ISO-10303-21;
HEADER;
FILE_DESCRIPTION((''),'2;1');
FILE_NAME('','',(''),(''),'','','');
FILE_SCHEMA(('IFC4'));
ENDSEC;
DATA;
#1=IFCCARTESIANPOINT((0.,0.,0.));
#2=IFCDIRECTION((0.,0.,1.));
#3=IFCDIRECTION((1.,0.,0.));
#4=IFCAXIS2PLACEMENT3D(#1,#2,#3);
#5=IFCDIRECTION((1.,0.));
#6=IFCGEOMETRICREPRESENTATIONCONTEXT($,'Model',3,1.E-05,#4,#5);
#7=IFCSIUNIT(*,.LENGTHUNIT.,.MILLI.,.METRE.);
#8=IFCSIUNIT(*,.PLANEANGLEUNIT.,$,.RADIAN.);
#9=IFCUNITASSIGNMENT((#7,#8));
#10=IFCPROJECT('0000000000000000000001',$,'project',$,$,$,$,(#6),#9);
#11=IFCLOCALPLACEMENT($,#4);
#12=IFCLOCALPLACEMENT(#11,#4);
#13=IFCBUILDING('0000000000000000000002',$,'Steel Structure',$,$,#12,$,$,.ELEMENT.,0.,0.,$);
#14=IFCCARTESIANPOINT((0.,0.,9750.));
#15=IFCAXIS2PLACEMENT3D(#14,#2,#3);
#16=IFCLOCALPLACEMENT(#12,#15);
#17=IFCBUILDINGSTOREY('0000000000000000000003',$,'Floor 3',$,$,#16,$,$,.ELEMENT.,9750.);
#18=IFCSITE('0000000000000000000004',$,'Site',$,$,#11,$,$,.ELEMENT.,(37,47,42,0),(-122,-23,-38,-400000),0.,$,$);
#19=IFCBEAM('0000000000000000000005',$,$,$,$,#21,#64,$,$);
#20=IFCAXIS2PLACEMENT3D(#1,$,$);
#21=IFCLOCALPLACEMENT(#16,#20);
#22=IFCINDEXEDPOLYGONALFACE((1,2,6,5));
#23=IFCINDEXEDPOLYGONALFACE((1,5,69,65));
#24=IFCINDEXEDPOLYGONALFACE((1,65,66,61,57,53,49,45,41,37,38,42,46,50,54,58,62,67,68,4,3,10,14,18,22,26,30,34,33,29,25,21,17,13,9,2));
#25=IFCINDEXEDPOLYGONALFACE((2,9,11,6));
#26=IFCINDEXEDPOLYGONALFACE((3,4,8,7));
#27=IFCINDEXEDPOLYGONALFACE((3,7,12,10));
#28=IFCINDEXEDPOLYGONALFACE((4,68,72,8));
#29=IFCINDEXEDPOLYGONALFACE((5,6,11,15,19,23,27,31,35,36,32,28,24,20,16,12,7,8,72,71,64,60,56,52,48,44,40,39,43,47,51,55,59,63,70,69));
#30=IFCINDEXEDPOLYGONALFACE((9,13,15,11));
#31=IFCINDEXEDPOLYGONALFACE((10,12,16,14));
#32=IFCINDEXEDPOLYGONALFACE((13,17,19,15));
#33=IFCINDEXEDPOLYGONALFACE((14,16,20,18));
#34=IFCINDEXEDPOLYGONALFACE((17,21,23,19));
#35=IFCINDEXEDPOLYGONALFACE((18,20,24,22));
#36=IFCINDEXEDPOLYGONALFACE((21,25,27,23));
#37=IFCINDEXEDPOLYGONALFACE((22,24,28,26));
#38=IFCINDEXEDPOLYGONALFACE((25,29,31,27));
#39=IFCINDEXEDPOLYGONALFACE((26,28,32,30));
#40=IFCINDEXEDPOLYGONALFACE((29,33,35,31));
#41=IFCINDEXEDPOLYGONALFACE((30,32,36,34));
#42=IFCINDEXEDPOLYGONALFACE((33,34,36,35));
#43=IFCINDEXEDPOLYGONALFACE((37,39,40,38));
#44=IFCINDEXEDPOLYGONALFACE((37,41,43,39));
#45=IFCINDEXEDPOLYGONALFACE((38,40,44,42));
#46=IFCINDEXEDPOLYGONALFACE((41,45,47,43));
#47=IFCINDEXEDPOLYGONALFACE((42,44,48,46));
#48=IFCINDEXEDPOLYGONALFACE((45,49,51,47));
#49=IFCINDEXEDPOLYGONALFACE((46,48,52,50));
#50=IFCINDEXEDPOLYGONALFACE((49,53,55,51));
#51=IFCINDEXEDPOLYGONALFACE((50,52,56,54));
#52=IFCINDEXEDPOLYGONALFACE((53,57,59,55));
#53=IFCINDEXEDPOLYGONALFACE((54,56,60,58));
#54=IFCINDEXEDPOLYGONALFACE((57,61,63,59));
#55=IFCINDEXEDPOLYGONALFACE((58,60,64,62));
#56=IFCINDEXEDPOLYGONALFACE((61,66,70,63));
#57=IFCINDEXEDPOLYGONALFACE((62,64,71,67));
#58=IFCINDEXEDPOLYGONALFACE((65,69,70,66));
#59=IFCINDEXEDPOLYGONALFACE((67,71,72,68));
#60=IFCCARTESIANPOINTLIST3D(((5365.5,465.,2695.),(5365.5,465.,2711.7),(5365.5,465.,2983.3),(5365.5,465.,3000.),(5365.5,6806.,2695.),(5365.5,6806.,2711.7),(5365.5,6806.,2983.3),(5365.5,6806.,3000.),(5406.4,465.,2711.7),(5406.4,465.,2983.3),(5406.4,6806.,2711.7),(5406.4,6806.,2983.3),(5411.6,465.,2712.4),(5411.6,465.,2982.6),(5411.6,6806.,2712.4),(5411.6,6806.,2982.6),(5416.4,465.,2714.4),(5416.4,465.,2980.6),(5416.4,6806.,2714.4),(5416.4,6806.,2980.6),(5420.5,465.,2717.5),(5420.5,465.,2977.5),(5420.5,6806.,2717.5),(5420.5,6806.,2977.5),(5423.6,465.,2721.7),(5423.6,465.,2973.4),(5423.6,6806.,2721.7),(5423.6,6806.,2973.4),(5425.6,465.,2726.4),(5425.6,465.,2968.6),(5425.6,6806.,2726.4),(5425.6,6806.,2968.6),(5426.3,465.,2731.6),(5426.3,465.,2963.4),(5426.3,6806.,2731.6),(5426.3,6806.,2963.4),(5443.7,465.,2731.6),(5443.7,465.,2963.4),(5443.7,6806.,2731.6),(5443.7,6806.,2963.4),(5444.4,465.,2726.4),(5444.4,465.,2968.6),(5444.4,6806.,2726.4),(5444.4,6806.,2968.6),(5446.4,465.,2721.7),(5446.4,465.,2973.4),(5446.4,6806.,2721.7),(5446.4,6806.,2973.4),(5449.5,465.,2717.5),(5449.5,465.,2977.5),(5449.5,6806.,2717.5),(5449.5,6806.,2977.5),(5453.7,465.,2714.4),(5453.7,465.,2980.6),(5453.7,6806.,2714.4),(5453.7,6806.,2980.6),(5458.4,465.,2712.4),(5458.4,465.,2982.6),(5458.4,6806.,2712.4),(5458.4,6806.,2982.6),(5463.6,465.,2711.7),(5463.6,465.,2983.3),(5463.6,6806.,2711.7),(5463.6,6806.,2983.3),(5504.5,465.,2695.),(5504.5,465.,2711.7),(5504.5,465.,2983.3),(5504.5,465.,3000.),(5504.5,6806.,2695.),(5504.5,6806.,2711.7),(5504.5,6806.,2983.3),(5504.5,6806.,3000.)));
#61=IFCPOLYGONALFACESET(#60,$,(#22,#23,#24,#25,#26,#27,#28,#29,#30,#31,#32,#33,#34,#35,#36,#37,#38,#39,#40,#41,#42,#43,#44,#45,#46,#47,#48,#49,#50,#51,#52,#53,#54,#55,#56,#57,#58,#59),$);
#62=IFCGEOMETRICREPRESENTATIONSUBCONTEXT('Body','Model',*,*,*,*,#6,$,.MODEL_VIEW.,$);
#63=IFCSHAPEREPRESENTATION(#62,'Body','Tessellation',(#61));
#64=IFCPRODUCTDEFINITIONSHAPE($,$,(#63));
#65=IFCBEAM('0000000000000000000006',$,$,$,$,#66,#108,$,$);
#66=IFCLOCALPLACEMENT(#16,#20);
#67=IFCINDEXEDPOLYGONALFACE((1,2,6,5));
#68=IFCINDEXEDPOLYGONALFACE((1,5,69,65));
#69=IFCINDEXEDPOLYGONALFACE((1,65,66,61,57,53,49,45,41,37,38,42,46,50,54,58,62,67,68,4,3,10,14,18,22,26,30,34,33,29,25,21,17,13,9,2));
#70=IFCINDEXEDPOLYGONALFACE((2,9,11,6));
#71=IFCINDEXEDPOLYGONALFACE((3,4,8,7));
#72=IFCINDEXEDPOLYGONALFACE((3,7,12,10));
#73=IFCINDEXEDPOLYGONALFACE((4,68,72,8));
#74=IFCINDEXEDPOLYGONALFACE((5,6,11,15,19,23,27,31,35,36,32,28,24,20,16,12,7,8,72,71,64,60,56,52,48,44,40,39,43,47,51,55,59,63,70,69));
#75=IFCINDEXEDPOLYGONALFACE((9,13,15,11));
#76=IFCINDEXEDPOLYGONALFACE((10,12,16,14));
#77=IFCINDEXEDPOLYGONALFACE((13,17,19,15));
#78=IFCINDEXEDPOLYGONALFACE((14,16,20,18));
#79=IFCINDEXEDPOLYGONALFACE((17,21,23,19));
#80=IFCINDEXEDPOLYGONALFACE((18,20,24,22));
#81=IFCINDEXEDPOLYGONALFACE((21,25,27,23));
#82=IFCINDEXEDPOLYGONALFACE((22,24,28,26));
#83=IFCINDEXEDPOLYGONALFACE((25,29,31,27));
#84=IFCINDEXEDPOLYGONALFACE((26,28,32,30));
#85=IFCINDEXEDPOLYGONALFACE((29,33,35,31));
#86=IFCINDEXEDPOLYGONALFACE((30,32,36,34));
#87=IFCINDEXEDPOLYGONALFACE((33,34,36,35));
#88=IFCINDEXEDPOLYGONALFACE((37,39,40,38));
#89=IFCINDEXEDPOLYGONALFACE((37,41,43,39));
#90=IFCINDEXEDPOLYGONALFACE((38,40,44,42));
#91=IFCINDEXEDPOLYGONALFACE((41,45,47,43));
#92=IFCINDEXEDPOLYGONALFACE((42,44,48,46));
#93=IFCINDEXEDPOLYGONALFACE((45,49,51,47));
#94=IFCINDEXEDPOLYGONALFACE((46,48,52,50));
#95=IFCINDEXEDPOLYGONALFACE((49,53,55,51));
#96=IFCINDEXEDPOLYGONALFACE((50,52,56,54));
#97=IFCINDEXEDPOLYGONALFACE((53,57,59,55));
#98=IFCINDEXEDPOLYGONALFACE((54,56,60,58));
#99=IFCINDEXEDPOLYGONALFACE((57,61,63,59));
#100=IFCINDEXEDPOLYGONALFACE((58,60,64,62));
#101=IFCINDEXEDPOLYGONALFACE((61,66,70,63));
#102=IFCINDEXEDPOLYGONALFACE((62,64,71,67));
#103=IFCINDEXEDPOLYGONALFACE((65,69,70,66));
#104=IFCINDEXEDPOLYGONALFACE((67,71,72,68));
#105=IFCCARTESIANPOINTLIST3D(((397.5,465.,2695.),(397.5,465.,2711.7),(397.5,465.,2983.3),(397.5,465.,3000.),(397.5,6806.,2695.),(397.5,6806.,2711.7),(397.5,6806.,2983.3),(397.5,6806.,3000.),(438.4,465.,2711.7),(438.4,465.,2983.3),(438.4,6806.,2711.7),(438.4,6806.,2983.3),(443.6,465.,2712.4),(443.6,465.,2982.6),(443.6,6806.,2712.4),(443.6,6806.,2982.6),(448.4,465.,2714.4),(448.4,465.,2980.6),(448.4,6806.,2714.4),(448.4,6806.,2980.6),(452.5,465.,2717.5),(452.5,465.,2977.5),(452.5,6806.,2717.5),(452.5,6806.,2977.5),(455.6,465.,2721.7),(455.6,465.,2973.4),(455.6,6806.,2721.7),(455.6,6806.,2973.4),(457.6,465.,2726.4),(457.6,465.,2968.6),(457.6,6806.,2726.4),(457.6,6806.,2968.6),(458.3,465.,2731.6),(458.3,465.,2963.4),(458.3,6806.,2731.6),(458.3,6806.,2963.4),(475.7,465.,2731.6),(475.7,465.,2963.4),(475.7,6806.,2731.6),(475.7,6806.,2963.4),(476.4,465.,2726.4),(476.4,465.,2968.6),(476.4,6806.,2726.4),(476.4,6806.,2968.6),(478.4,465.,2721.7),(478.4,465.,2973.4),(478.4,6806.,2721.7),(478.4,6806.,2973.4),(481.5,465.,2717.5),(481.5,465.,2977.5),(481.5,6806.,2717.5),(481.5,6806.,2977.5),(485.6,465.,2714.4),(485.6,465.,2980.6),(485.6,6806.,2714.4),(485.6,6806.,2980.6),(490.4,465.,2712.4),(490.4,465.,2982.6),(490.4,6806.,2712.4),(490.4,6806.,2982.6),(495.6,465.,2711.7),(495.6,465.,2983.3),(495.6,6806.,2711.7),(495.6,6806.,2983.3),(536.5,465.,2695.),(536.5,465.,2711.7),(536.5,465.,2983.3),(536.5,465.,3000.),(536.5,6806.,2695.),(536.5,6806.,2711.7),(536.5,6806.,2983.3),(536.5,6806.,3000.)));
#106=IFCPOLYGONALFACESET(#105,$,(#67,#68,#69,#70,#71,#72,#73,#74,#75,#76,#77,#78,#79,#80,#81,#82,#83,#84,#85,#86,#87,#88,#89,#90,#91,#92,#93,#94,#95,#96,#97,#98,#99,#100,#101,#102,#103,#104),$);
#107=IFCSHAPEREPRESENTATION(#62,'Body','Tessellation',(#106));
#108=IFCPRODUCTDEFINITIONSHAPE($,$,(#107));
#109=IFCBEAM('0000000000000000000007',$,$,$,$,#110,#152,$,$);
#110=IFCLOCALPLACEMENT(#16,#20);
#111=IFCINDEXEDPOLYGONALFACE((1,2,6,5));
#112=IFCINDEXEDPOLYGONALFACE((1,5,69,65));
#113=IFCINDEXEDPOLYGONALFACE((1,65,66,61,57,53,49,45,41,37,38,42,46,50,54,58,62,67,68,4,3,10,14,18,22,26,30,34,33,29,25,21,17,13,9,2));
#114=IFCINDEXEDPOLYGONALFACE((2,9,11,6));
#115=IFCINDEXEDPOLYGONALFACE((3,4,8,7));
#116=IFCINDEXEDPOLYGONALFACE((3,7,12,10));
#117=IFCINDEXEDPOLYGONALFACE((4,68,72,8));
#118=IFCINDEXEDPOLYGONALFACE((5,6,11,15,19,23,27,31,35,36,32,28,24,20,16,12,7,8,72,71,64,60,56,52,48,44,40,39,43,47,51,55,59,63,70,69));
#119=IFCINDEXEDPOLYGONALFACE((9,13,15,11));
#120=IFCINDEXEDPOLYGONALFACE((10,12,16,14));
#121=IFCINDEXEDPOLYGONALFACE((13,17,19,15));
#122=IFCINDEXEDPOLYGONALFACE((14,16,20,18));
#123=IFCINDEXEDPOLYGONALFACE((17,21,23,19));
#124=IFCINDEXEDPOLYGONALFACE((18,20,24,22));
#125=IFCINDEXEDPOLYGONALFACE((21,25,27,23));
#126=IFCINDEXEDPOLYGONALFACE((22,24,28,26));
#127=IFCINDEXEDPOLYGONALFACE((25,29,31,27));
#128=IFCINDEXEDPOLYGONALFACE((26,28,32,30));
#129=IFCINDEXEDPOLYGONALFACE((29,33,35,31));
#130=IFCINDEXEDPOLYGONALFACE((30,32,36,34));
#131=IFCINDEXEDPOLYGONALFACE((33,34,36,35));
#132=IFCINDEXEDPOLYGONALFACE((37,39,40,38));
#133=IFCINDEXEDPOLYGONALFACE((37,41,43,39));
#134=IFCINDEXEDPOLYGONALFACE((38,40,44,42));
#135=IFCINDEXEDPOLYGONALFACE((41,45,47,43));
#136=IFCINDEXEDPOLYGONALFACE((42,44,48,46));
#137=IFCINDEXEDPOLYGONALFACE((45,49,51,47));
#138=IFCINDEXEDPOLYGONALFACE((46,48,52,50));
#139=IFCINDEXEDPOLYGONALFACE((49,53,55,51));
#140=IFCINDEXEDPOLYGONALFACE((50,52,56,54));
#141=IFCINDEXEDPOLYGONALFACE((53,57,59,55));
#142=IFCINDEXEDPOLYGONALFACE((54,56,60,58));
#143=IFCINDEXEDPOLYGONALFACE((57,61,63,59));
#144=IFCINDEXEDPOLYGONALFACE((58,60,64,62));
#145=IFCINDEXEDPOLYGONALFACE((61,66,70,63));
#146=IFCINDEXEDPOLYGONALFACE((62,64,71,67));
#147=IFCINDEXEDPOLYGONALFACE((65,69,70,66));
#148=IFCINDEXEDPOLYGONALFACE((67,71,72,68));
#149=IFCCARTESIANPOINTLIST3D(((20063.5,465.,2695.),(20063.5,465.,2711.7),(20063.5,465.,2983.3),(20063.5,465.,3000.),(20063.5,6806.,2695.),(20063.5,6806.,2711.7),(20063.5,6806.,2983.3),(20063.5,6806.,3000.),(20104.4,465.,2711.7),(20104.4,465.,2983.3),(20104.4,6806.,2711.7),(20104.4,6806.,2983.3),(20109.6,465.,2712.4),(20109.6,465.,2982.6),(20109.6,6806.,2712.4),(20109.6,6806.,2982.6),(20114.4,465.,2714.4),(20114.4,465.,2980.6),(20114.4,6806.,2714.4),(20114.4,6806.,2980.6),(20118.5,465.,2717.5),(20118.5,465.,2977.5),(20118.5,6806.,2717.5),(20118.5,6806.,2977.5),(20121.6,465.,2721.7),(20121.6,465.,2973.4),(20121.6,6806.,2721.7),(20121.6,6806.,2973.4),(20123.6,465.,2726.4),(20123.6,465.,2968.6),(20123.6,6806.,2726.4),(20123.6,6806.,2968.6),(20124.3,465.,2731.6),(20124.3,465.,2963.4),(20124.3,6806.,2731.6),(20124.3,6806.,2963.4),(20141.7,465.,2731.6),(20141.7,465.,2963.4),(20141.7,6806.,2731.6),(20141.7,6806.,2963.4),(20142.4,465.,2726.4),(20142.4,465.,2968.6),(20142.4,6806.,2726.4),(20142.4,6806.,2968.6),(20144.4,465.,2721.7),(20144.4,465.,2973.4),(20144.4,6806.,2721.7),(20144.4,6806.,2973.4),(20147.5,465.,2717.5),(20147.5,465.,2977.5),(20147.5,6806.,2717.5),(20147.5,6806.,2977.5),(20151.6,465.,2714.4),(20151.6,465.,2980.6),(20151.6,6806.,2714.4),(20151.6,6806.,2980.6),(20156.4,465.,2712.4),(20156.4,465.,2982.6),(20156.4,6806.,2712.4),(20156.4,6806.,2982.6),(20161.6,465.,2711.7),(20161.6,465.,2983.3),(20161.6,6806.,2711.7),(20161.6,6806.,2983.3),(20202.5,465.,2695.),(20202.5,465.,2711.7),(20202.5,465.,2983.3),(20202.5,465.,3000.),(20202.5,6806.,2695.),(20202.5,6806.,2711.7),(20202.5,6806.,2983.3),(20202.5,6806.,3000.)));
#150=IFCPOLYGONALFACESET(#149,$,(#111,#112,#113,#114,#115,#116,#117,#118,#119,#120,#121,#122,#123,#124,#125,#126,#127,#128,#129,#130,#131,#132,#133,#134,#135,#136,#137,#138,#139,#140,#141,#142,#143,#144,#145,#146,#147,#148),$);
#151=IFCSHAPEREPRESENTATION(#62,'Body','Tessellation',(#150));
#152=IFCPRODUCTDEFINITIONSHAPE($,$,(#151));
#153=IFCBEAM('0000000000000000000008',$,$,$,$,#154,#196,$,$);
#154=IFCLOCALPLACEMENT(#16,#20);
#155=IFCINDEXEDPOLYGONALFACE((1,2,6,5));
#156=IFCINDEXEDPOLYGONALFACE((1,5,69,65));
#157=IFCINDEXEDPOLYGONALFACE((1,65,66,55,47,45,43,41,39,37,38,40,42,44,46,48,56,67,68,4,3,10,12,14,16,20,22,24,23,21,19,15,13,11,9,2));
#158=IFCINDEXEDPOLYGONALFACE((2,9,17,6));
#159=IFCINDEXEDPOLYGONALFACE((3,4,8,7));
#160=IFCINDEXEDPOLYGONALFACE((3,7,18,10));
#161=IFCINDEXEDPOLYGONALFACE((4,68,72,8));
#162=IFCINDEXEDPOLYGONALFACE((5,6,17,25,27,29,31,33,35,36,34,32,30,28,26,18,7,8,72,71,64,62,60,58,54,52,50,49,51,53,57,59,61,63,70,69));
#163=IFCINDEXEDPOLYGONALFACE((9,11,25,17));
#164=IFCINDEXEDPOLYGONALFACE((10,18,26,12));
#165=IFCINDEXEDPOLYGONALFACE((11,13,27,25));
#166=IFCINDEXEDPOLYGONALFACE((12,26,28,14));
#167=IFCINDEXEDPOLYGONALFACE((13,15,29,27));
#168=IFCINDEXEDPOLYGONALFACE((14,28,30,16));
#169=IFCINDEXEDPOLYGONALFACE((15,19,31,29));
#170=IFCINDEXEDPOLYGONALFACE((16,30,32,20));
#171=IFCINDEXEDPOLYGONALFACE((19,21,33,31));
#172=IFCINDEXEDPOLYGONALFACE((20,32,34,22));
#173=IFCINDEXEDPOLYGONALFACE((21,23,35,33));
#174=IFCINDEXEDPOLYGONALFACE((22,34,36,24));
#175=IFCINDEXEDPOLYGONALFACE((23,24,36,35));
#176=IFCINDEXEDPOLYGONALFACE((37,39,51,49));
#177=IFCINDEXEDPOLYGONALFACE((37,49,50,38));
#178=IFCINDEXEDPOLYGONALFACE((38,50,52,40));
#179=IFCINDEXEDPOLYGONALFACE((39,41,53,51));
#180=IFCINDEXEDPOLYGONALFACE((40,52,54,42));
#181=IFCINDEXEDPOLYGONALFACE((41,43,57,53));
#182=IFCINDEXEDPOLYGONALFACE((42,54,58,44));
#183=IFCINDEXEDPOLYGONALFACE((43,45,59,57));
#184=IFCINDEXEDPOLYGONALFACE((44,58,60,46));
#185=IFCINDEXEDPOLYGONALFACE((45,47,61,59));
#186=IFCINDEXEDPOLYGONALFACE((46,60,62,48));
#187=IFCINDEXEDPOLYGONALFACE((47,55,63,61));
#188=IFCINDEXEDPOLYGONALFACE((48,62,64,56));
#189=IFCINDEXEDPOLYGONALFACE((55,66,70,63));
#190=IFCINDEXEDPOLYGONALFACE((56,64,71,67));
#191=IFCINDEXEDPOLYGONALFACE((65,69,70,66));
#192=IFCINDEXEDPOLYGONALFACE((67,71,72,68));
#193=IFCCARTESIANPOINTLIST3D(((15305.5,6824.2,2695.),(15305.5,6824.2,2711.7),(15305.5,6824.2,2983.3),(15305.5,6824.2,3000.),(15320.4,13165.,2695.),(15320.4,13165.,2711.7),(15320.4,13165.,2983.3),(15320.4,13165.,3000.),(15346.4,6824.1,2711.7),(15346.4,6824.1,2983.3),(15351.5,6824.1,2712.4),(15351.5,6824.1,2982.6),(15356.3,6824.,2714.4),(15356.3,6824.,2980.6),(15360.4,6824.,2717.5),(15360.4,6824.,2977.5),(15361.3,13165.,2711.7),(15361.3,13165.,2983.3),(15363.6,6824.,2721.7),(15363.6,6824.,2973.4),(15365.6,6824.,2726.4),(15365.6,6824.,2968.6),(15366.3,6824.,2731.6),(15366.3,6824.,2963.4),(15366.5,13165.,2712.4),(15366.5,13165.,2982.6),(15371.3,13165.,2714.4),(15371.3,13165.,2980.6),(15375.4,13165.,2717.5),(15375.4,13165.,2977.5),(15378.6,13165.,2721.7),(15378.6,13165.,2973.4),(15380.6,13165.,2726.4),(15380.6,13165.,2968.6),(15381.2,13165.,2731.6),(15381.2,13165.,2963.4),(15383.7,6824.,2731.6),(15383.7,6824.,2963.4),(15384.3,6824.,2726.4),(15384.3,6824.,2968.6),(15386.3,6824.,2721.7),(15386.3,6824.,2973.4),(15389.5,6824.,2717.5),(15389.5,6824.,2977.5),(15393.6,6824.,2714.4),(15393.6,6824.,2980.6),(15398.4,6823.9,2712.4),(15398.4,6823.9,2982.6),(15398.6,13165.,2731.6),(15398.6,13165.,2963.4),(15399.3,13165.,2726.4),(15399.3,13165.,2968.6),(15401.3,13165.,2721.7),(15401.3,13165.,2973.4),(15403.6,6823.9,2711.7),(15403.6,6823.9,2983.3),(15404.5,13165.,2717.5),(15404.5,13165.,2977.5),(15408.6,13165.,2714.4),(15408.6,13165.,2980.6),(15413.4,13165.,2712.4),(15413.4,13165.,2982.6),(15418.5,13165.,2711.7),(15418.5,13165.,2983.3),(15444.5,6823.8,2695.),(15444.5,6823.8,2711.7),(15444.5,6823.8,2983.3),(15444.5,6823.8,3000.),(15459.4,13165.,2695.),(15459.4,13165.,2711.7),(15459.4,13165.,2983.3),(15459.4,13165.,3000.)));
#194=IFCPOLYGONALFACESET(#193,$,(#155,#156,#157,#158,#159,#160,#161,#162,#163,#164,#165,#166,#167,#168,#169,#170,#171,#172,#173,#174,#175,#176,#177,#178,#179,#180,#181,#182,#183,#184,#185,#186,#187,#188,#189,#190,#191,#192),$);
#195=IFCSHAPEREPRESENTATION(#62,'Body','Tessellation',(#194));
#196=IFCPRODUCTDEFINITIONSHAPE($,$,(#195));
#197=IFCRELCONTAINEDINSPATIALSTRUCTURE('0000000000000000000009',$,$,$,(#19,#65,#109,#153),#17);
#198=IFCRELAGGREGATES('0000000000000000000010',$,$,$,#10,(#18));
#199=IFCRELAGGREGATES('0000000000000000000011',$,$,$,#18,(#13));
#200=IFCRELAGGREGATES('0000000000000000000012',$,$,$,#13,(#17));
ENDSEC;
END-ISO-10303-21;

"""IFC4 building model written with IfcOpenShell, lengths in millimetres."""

from ifc_helpers import new_model, si_unit, direction, frame, origin_with_axes, origin_2d_with_axis, place, context, subcontext, project, spatial, polyline, i_section, extrude, clip, bounded_halfspace, element, save


model = new_model("IFC4")

# Units and contexts
model_context = context("Model", 3, precision=1e-05, world=origin_with_axes(), true_north=direction((1.0, 0.0)))
body_context = subcontext(model_context, "Body", "Model", "MODEL_VIEW")
ifc_project = project(units=[si_unit("LENGTHUNIT", "METRE", prefix="MILLI"), si_unit("PLANEANGLEUNIT", "RADIAN")], contexts=[model_context])

# Site, building, storey
site_placement = place(None, origin_with_axes())
site = spatial("IfcSite", under=ifc_project, at=site_placement, Name="Site", CompositionType="ELEMENT", RefLatitude=(37, 47, 42, 0), RefLongitude=(-122, -23, -38, -400000), RefElevation=0.0)
building_placement = place(site_placement, origin_with_axes())
building = spatial("IfcBuilding", under=site, at=building_placement, Name="Steel Structure", CompositionType="ELEMENT", ElevationOfRefHeight=0.0, ElevationOfTerrain=0.0)
storey_placement = place(building_placement, frame((0.0, 0.0, 9750.0), z_axis=(0.0, 0.0, 1.0), x_axis=(1.0, 0.0, 0.0)))
storey = spatial("IfcBuildingStorey", under=building, at=storey_placement, Name="Floor 3", CompositionType="ELEMENT", Elevation=9750.0)

# Beams
for number, where, z_axis, x_axis in (
    (1, (5435.0, 6806.0, 2847.5), (0.0, -1.0, 0.0), (1.0, 0.0, 0.0)),
    (2, (467.0, 465.0, 2847.5), (0.0, 1.0, 0.0), (-1.0, 0.0, 0.0)),
    (3, (20133.0, 6806.0, 2847.5), (0.0, -1.0, 0.0), (1.0, 0.0, 0.0)),
):
    element("IfcBeam", number, at=place(storey_placement, frame(where, z_axis=z_axis, x_axis=x_axis)), inside=storey, context=body_context, shape_type="SweptSolid", body=[
        extrude(i_section(OverallWidth=139.0, OverallDepth=305.0, WebThickness=17.4, FlangeThickness=16.7, FilletRadius=19.9, at=origin_2d_with_axis()), origin_with_axes(), (0.0, 0.0, 1.0), 6341.0),
    ])
beam_1_placement = place(storey_placement, frame((15389.9, 13165.2, 2695.0), z_axis=(-0.002362, -0.999997, 0.0), x_axis=(0.999997, -0.002362, 0.0)))
element("IfcBeam", 4, at=beam_1_placement, inside=storey, context=body_context, shape_type="Clipping", body=[
    clip(extrude(i_section(OverallWidth=139.0, OverallDepth=305.0, WebThickness=17.4, FlangeThickness=16.7, FilletRadius=19.9, at=origin_2d_with_axis()), frame((0.0, 152.5, 0.0), z_axis=(0.0, 0.0, 1.0), x_axis=(1.0, 0.0, 0.0)), (0.0, 0.0, 1.0), 6341.2), bounded_halfspace(frame((-15389.9, -12445.0, 36.5), z_axis=(-0.002362, 0.0, -0.999997), x_axis=(-0.999997, 0.0, 0.002362)), False, frame((0.0, 152.5, 0.0), z_axis=(0.0, 0.0, 1.0), x_axis=(1.0, 0.0, 0.0)), polyline([(69.5, 152.5), (69.5, 135.8), (28.6, 135.8), (8.7, 115.9), (8.7, -115.9), (28.6, -135.8), (69.5, -135.8), (69.5, -152.5), (-69.5, -152.5), (-69.5, -135.8), (-28.6, -135.8), (-8.7, -115.9), (-8.7, 115.9), (-28.6, 135.8), (-69.5, 135.8), (-69.5, 152.5), (69.5, 152.5)]))),
])

save(model, "model.ifc")
